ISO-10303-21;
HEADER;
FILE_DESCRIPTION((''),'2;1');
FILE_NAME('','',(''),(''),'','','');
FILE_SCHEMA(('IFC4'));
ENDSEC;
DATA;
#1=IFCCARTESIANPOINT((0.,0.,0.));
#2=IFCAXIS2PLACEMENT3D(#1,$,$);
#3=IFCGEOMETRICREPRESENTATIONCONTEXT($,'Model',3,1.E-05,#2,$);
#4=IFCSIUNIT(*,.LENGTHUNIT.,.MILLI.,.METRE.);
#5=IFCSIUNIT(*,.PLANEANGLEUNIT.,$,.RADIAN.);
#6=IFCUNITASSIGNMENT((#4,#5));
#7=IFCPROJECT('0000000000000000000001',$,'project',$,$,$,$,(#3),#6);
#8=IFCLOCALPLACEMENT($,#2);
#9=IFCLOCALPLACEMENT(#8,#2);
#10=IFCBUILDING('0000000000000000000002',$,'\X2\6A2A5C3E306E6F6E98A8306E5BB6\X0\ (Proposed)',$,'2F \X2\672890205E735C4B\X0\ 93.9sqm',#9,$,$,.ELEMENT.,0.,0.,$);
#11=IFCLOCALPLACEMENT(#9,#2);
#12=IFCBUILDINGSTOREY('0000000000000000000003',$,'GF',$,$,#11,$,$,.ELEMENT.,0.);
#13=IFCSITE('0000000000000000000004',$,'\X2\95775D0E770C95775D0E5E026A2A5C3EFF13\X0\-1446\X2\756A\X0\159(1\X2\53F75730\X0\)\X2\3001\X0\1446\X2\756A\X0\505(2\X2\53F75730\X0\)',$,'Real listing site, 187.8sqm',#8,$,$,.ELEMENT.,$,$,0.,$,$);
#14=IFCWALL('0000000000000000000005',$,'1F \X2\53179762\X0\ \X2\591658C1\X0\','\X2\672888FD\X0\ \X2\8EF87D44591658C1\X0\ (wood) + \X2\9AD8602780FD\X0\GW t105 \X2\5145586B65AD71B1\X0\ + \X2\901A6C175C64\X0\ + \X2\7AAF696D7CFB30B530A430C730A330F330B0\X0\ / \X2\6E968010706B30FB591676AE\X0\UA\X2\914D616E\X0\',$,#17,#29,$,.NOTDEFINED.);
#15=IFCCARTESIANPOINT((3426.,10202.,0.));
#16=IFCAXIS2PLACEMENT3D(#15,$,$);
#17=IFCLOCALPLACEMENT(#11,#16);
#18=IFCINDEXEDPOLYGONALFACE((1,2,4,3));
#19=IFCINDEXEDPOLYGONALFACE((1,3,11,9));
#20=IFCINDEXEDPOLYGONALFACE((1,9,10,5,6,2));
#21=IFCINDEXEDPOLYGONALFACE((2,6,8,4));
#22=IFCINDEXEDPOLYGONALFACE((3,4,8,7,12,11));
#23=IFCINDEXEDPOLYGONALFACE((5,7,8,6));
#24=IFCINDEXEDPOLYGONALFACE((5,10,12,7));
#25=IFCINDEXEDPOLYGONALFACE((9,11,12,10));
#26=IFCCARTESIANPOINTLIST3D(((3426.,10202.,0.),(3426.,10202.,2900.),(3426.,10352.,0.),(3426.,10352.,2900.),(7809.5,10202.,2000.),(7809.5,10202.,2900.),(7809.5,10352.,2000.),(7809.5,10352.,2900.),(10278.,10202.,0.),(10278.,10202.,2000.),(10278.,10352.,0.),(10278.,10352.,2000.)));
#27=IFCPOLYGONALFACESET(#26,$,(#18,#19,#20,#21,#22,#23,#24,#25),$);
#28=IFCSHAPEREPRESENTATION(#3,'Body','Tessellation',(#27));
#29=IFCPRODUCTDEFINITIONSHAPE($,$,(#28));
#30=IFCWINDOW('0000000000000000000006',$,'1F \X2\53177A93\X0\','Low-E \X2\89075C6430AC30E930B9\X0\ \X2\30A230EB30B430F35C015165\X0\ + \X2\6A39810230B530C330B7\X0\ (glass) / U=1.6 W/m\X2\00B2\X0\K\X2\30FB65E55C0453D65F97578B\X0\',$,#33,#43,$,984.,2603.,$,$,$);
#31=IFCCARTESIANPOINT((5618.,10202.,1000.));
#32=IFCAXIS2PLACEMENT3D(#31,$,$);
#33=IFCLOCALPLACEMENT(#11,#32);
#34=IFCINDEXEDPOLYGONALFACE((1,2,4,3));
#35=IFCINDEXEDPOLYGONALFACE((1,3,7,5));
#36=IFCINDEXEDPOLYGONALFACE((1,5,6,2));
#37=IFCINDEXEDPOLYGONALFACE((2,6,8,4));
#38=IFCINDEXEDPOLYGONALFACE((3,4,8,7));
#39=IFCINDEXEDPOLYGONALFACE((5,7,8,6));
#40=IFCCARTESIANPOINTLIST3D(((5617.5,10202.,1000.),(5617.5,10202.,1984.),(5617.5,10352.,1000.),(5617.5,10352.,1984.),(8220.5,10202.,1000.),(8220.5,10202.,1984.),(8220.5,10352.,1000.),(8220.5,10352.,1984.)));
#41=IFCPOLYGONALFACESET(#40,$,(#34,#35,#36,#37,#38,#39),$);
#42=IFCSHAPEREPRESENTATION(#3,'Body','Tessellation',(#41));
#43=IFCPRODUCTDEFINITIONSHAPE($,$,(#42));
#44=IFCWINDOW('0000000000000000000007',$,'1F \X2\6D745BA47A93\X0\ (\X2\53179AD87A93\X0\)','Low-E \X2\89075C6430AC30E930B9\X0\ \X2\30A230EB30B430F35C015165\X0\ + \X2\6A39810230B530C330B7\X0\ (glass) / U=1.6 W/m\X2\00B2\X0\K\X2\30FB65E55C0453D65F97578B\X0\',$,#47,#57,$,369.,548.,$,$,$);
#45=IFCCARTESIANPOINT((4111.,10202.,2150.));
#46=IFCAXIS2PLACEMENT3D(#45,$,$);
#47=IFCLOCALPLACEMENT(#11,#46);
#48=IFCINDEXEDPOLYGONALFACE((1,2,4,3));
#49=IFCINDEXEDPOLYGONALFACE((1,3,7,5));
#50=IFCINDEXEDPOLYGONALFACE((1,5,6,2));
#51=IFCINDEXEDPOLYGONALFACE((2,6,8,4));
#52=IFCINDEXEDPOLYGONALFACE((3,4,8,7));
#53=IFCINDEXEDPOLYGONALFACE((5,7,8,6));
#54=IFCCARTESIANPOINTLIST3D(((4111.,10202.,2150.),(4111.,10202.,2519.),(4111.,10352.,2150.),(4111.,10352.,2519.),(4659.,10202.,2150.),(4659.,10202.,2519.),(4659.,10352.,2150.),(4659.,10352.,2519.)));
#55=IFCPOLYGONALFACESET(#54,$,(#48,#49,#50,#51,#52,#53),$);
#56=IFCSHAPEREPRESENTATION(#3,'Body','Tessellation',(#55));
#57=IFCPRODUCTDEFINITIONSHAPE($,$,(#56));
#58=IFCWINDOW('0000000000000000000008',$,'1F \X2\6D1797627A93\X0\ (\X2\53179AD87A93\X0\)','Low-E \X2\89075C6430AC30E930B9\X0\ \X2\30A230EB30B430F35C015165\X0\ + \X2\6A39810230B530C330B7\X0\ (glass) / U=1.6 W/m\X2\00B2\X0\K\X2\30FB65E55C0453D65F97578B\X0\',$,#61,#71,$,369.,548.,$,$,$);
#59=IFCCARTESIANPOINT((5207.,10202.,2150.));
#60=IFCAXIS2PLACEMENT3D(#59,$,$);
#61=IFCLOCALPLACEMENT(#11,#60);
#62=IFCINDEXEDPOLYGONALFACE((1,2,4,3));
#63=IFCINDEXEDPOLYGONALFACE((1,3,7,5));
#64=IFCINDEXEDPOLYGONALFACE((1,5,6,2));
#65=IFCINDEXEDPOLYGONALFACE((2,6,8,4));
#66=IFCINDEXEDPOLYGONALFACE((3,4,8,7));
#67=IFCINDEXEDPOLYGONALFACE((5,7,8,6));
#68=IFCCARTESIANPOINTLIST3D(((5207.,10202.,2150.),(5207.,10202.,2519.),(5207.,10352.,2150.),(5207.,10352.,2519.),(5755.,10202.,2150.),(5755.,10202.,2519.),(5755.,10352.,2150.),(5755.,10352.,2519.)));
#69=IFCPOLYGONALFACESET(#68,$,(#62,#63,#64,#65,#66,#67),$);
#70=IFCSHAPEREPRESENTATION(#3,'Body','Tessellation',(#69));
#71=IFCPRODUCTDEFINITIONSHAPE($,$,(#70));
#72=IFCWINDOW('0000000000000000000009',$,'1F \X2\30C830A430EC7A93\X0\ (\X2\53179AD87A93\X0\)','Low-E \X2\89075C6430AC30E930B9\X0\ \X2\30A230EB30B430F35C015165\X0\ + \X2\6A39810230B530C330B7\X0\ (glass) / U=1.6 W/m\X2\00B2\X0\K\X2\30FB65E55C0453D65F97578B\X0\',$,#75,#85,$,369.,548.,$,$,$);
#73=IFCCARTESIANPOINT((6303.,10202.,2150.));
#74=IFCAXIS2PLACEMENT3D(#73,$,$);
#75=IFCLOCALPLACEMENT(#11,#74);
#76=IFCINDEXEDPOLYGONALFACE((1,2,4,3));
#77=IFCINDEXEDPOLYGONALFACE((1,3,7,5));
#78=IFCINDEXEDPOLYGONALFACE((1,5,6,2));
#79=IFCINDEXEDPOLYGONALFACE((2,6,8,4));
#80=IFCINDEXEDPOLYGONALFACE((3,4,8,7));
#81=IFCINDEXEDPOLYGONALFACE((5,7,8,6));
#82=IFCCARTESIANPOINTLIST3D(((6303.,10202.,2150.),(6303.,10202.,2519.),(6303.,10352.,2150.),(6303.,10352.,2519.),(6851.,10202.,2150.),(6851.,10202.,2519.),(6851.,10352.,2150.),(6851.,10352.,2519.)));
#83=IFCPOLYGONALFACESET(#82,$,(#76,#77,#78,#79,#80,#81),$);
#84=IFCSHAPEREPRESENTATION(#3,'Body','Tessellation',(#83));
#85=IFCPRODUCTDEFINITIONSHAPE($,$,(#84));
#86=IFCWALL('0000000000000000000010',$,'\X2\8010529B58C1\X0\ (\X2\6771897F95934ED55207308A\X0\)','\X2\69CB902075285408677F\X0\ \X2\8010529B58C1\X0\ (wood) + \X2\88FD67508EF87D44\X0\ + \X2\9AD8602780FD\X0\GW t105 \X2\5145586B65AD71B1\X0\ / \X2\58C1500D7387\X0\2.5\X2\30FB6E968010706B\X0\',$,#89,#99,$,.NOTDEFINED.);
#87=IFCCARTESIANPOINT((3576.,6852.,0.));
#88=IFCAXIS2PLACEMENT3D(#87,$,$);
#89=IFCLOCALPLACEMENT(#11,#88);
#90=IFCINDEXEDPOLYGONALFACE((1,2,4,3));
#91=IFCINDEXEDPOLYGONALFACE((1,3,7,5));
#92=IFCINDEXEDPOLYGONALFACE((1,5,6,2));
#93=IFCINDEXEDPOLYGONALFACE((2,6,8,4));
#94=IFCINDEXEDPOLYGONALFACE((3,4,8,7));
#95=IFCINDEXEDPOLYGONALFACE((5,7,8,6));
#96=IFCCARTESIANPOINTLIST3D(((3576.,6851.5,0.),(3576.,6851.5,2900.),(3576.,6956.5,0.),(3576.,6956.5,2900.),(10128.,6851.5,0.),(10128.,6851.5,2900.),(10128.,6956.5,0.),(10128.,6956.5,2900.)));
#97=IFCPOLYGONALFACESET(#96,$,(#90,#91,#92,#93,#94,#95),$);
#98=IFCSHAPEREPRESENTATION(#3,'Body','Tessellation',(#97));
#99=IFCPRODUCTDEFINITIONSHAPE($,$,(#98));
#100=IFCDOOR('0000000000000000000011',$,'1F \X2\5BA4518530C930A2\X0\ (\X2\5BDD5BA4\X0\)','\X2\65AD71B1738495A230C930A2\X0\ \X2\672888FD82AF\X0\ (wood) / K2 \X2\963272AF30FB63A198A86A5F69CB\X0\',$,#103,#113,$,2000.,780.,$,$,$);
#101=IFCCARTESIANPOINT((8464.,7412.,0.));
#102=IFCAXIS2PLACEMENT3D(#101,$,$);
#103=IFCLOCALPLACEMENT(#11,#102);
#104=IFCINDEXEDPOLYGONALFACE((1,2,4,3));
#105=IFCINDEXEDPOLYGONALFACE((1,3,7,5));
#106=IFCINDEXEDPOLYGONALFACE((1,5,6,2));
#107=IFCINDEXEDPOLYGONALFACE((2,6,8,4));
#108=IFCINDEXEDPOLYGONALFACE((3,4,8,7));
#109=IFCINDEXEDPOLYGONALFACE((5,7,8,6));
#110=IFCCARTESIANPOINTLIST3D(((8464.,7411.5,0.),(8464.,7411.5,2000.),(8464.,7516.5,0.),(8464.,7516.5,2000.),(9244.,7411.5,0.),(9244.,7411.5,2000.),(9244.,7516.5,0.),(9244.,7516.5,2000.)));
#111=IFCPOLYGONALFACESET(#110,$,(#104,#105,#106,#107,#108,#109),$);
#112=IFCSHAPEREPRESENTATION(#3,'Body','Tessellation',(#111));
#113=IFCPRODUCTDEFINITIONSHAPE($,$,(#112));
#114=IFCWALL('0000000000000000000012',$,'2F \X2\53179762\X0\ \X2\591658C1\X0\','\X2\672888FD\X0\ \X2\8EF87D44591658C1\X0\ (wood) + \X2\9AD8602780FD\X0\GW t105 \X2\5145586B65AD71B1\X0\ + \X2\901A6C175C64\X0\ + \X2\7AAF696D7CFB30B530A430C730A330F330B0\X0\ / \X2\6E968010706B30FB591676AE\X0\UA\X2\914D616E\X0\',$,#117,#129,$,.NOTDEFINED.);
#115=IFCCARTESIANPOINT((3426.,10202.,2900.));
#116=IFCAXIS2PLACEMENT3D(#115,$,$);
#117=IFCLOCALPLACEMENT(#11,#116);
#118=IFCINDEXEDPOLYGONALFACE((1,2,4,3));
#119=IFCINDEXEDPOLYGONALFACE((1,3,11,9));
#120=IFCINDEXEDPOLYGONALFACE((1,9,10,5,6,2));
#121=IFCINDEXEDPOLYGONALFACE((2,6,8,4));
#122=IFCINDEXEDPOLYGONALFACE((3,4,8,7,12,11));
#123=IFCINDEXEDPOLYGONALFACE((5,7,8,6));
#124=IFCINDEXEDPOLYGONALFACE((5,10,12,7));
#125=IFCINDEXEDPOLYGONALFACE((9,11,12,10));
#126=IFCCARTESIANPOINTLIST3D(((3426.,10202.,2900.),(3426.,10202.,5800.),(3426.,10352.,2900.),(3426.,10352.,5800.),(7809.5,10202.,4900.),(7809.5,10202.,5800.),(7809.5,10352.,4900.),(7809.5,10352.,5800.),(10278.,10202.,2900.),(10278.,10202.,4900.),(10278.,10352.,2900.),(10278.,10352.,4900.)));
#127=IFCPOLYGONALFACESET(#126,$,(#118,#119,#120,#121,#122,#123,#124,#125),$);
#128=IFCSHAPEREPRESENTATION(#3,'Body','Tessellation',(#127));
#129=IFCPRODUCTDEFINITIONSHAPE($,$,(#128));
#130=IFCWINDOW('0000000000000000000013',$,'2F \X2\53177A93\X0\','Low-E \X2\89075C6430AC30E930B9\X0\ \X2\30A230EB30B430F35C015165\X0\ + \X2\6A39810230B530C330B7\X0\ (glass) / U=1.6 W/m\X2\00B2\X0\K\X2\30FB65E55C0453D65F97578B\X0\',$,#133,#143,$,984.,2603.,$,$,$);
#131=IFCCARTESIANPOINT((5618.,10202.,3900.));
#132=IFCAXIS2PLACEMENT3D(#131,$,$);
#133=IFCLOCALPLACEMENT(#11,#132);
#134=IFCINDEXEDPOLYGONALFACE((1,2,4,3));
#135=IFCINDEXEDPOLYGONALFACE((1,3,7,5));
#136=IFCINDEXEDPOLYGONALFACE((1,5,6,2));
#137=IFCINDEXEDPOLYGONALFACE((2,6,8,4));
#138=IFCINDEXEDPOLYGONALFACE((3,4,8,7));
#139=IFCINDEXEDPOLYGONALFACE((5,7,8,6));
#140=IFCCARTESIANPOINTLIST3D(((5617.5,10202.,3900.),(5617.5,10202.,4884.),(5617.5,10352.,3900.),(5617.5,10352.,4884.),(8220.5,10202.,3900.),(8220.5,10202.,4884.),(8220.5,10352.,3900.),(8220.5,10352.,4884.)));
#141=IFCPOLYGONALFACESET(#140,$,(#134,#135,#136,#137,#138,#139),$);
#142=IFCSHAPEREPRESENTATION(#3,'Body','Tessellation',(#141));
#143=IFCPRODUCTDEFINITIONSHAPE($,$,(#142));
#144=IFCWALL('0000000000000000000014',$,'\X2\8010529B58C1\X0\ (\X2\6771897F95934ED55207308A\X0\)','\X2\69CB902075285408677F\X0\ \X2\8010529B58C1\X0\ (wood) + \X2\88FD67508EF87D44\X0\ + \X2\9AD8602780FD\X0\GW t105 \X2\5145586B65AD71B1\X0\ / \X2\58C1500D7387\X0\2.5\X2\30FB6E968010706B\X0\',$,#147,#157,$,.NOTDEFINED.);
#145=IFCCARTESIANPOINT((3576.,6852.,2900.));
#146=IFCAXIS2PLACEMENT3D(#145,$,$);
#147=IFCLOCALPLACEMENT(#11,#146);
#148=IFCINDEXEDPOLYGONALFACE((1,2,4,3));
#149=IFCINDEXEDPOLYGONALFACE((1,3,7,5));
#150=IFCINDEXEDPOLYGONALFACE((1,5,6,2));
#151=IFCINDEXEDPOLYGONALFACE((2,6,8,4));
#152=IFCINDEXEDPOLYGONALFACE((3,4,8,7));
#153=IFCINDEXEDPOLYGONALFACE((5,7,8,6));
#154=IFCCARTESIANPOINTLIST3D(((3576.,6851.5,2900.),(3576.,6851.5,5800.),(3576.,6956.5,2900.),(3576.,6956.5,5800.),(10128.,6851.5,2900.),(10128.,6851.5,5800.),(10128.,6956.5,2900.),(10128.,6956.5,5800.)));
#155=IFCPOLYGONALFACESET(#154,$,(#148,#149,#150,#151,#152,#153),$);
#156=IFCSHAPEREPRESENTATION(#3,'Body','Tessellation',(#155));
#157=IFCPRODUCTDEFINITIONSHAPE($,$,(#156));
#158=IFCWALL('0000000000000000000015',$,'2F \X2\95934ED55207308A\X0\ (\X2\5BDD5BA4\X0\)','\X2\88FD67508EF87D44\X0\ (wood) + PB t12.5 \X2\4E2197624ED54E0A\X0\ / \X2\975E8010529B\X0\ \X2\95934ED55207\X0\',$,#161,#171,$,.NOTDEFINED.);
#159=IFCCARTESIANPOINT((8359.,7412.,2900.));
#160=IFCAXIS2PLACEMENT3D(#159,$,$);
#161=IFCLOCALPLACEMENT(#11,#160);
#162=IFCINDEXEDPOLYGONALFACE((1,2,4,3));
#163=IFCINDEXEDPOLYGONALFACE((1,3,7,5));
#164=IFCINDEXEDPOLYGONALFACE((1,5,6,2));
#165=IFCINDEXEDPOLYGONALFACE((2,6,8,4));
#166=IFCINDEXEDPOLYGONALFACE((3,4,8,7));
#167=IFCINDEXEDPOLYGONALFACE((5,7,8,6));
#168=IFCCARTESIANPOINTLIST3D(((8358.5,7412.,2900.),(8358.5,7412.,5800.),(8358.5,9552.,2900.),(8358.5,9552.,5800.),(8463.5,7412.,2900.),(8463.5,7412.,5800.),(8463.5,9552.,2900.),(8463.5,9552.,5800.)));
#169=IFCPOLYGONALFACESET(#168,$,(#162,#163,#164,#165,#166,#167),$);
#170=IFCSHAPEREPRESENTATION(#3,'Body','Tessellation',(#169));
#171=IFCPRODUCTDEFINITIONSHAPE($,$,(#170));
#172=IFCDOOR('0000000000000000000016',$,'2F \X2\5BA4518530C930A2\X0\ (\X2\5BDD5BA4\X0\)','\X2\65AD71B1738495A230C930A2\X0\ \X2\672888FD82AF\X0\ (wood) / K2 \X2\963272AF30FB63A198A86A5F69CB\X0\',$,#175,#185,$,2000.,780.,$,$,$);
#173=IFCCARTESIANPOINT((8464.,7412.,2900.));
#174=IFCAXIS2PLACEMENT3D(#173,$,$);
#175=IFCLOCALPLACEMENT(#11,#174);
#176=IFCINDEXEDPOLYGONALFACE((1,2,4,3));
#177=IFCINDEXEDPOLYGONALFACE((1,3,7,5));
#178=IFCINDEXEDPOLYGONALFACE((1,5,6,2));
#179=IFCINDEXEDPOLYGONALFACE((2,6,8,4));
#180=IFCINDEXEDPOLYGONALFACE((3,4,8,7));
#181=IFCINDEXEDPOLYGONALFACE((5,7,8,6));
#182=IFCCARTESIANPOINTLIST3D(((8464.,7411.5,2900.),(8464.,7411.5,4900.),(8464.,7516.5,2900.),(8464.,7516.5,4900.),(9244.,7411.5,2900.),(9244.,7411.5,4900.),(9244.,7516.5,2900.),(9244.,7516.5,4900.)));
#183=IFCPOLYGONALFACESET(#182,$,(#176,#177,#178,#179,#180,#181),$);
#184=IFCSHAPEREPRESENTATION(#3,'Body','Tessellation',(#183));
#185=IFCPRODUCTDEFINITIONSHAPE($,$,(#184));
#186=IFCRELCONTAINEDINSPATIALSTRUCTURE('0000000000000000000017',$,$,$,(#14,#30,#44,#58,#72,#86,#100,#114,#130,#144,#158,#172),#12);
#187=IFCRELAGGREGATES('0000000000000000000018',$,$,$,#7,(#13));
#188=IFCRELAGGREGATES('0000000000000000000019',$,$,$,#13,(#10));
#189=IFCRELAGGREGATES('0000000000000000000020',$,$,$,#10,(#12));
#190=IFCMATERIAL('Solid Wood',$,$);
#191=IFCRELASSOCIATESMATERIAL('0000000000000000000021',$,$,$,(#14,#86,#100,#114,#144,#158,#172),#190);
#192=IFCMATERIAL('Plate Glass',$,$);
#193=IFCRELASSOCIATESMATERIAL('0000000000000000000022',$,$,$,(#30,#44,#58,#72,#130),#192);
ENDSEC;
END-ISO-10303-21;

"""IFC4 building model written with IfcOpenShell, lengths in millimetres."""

from ifc_helpers import new_model, si_unit, frame, frame_2d, origin, place, context, project, spatial, rectangle, extrude, material, element, fill, save


model = new_model("IFC4")

# Units and contexts
model_context = context("Model", 3, precision=1e-05, world=origin())
ifc_project = project(units=[si_unit("LENGTHUNIT", "METRE", prefix="MILLI"), si_unit("PLANEANGLEUNIT", "RADIAN")], contexts=[model_context])

# Site, building, storey
site_placement = place(None, origin())
site = spatial("IfcSite", under=ifc_project, at=site_placement, Name="長崎県長崎市横尾３-1446番159(1号地)、1446番505(2号地)", ObjectType="Real listing site, 187.8sqm", CompositionType="ELEMENT", RefElevation=0.0)
building_placement = place(site_placement, origin())
building = spatial("IfcBuilding", under=site, at=building_placement, Name="横尾の潮風の家 (Proposed)", ObjectType="2F 木造平屋 93.9sqm", CompositionType="ELEMENT", ElevationOfRefHeight=0.0, ElevationOfTerrain=0.0)
storey_placement = place(building_placement, origin())
storey = spatial("IfcBuildingStorey", under=building, at=storey_placement, Name="GF", CompositionType="ELEMENT", Elevation=0.0)

# Wall, openings, windows
ifc_material_1 = material(Name="Solid Wood")
wall_1_placement = place(storey_placement, frame((3426.0, 10202.0, 0.0)))
wall_1 = element("IfcWall", 1, at=wall_1_placement, inside=storey, material=ifc_material_1, Name="1F 北面 外壁", Description="木製 軸組外壁 (wood) + 高性能GW t105 充填断熱 + 通気層 + 窯業系サイディング / 準耐火・外皮UA配慮", PredefinedType="NOTDEFINED", context=model_context, shape_type="SweptSolid", body=[
    extrude(rectangle(XDim=6852.0, YDim=150.0, at=frame_2d((3426.0, 75.0))), frame((3426.0, 10202.0, 0.0)), (0.0, 0.0, 1.0), 2900.0),
])
opening_1_placement = place(storey_placement, frame((5618.0, 10202.0, 1000.0)))
opening_1 = element("IfcOpeningElement", 2, at=opening_1_placement, cuts=wall_1, PredefinedType="NOTDEFINED", context=model_context, shape_type="SweptSolid", body=[
    extrude(rectangle(XDim=2603.0, YDim=150.0, at=frame_2d((1301.0, 75.0))), frame((5618.0, 10202.0, 1000.0)), (0.0, 0.0, 1.0), 984.0),
])
opening_2_placement = place(storey_placement, frame((4111.0, 10202.0, 2150.0)))
opening_2 = element("IfcOpeningElement", 3, at=opening_2_placement, cuts=wall_1, PredefinedType="NOTDEFINED", context=model_context, shape_type="SweptSolid", body=[
    extrude(rectangle(XDim=548.0, YDim=150.0, at=frame_2d((274.0, 75.0))), frame((4111.0, 10202.0, 2150.0)), (0.0, 0.0, 1.0), 369.0),
])
opening_3_placement = place(storey_placement, frame((5207.0, 10202.0, 2150.0)))
opening_3 = element("IfcOpeningElement", 4, at=opening_3_placement, cuts=wall_1, PredefinedType="NOTDEFINED", context=model_context, shape_type="SweptSolid", body=[
    extrude(rectangle(XDim=548.0, YDim=150.0, at=frame_2d((274.0, 75.0))), frame((5207.0, 10202.0, 2150.0)), (0.0, 0.0, 1.0), 369.0),
])
opening_4_placement = place(storey_placement, frame((6303.0, 10202.0, 2150.0)))
opening_4 = element("IfcOpeningElement", 5, at=opening_4_placement, cuts=wall_1, PredefinedType="NOTDEFINED", context=model_context, shape_type="SweptSolid", body=[
    extrude(rectangle(XDim=548.0, YDim=150.0, at=frame_2d((274.0, 75.0))), frame((6303.0, 10202.0, 2150.0)), (0.0, 0.0, 1.0), 369.0),
])
ifc_material_2 = material(Name="Plate Glass")
window_1_placement = place(storey_placement, frame((5618.0, 10202.0, 1000.0)))
window_1 = element("IfcWindow", 6, at=window_1_placement, inside=storey, material=ifc_material_2, Name="1F 北窓", Description="Low-E 複層ガラス アルゴン封入 + 樹脂サッシ (glass) / U=1.6 W/m²K・日射取得型", OverallHeight=984.0, OverallWidth=2603.0, context=model_context, shape_type="SweptSolid", body=[
    extrude(rectangle(XDim=2603.0, YDim=150.0, at=frame_2d((1301.0, 75.0))), frame((5618.0, 10202.0, 1000.0)), (0.0, 0.0, 1.0), 984.0),
])
fill(opening_1, window_1)
window_2_placement = place(storey_placement, frame((4111.0, 10202.0, 2150.0)))
window_2 = element("IfcWindow", 7, at=window_2_placement, inside=storey, material=ifc_material_2, Name="1F 浴室窓 (北高窓)", Description="Low-E 複層ガラス アルゴン封入 + 樹脂サッシ (glass) / U=1.6 W/m²K・日射取得型", OverallHeight=369.0, OverallWidth=548.0, context=model_context, shape_type="SweptSolid", body=[
    extrude(rectangle(XDim=548.0, YDim=150.0, at=frame_2d((274.0, 75.0))), frame((4111.0, 10202.0, 2150.0)), (0.0, 0.0, 1.0), 369.0),
])
fill(opening_2, window_2)
window_3_placement = place(storey_placement, frame((5207.0, 10202.0, 2150.0)))
window_3 = element("IfcWindow", 8, at=window_3_placement, inside=storey, material=ifc_material_2, Name="1F 洗面窓 (北高窓)", Description="Low-E 複層ガラス アルゴン封入 + 樹脂サッシ (glass) / U=1.6 W/m²K・日射取得型", OverallHeight=369.0, OverallWidth=548.0, context=model_context, shape_type="SweptSolid", body=[
    extrude(rectangle(XDim=548.0, YDim=150.0, at=frame_2d((274.0, 75.0))), frame((5207.0, 10202.0, 2150.0)), (0.0, 0.0, 1.0), 369.0),
])
fill(opening_3, window_3)
window_4_placement = place(storey_placement, frame((6303.0, 10202.0, 2150.0)))
window_4 = element("IfcWindow", 9, at=window_4_placement, inside=storey, material=ifc_material_2, Name="1F トイレ窓 (北高窓)", Description="Low-E 複層ガラス アルゴン封入 + 樹脂サッシ (glass) / U=1.6 W/m²K・日射取得型", OverallHeight=369.0, OverallWidth=548.0, context=model_context, shape_type="SweptSolid", body=[
    extrude(rectangle(XDim=548.0, YDim=150.0, at=frame_2d((274.0, 75.0))), frame((6303.0, 10202.0, 2150.0)), (0.0, 0.0, 1.0), 369.0),
])
fill(opening_4, window_4)

# Wall
wall_2_placement = place(storey_placement, frame((3576.0, 6852.0, 0.0)))
element("IfcWall", 10, at=wall_2_placement, inside=storey, material=ifc_material_1, Name="耐力壁 (東西間仕切り)", Description="構造用合板 耐力壁 (wood) + 製材軸組 + 高性能GW t105 充填断熱 / 壁倍率2.5・準耐火", PredefinedType="NOTDEFINED", context=model_context, shape_type="SweptSolid", body=[
    extrude(rectangle(XDim=6552.0, YDim=105.0, at=frame_2d((3276.0, 52.0))), frame((3576.0, 6852.0, 0.0)), (0.0, 0.0, 1.0), 2900.0),
])

# Door
door_1_placement = place(storey_placement, frame((8464.0, 7412.0, 0.0)))
element("IfcDoor", 11, at=door_1_placement, inside=storey, material=ifc_material_1, Name="1F 室内ドア (寝室)", Description="断熱玄関ドア 木製芯 (wood) / K2 防犯・採風機構", OverallHeight=2000.0, OverallWidth=780.0, context=model_context, shape_type="SweptSolid", body=[
    extrude(rectangle(XDim=780.0, YDim=105.0, at=frame_2d((390.0, 52.0))), frame((8464.0, 7412.0, 0.0)), (0.0, 0.0, 1.0), 2000.0),
])

# Wall, opening, window
wall_3_placement = place(storey_placement, frame((3426.0, 10202.0, 2900.0)))
wall_3 = element("IfcWall", 12, at=wall_3_placement, inside=storey, material=ifc_material_1, Name="2F 北面 外壁", Description="木製 軸組外壁 (wood) + 高性能GW t105 充填断熱 + 通気層 + 窯業系サイディング / 準耐火・外皮UA配慮", PredefinedType="NOTDEFINED", context=model_context, shape_type="SweptSolid", body=[
    extrude(rectangle(XDim=6852.0, YDim=150.0, at=frame_2d((3426.0, 75.0))), frame((3426.0, 10202.0, 2900.0)), (0.0, 0.0, 1.0), 2900.0),
])
opening_5_placement = place(storey_placement, frame((5618.0, 10202.0, 3900.0)))
opening_5 = element("IfcOpeningElement", 13, at=opening_5_placement, cuts=wall_3, PredefinedType="NOTDEFINED", context=model_context, shape_type="SweptSolid", body=[
    extrude(rectangle(XDim=2603.0, YDim=150.0, at=frame_2d((1301.0, 75.0))), frame((5618.0, 10202.0, 3900.0)), (0.0, 0.0, 1.0), 984.0),
])
window_5_placement = place(storey_placement, frame((5618.0, 10202.0, 3900.0)))
window_5 = element("IfcWindow", 14, at=window_5_placement, inside=storey, material=ifc_material_2, Name="2F 北窓", Description="Low-E 複層ガラス アルゴン封入 + 樹脂サッシ (glass) / U=1.6 W/m²K・日射取得型", OverallHeight=984.0, OverallWidth=2603.0, context=model_context, shape_type="SweptSolid", body=[
    extrude(rectangle(XDim=2603.0, YDim=150.0, at=frame_2d((1301.0, 75.0))), frame((5618.0, 10202.0, 3900.0)), (0.0, 0.0, 1.0), 984.0),
])
fill(opening_5, window_5)

# Walls
wall_4_placement = place(storey_placement, frame((3576.0, 6852.0, 2900.0)))
element("IfcWall", 15, at=wall_4_placement, inside=storey, material=ifc_material_1, Name="耐力壁 (東西間仕切り)", Description="構造用合板 耐力壁 (wood) + 製材軸組 + 高性能GW t105 充填断熱 / 壁倍率2.5・準耐火", PredefinedType="NOTDEFINED", context=model_context, shape_type="SweptSolid", body=[
    extrude(rectangle(XDim=6552.0, YDim=105.0, at=frame_2d((3276.0, 52.0))), frame((3576.0, 6852.0, 2900.0)), (0.0, 0.0, 1.0), 2900.0),
])
wall_5_placement = place(storey_placement, frame((8359.0, 7412.0, 2900.0)))
element("IfcWall", 16, at=wall_5_placement, inside=storey, material=ifc_material_1, Name="2F 間仕切り (寝室)", Description="製材軸組 (wood) + PB t12.5 両面仕上 / 非耐力 間仕切", PredefinedType="NOTDEFINED", context=model_context, shape_type="SweptSolid", body=[
    extrude(rectangle(XDim=105.0, YDim=2140.0, at=frame_2d((52.0, 1070.0))), frame((8359.0, 7412.0, 2900.0)), (0.0, 0.0, 1.0), 2900.0),
])

# Door
door_2_placement = place(storey_placement, frame((8464.0, 7412.0, 2900.0)))
element("IfcDoor", 17, at=door_2_placement, inside=storey, material=ifc_material_1, Name="2F 室内ドア (寝室)", Description="断熱玄関ドア 木製芯 (wood) / K2 防犯・採風機構", OverallHeight=2000.0, OverallWidth=780.0, context=model_context, shape_type="SweptSolid", body=[
    extrude(rectangle(XDim=780.0, YDim=105.0, at=frame_2d((390.0, 52.0))), frame((8464.0, 7412.0, 2900.0)), (0.0, 0.0, 1.0), 2000.0),
])

save(model, "model.ifc")
